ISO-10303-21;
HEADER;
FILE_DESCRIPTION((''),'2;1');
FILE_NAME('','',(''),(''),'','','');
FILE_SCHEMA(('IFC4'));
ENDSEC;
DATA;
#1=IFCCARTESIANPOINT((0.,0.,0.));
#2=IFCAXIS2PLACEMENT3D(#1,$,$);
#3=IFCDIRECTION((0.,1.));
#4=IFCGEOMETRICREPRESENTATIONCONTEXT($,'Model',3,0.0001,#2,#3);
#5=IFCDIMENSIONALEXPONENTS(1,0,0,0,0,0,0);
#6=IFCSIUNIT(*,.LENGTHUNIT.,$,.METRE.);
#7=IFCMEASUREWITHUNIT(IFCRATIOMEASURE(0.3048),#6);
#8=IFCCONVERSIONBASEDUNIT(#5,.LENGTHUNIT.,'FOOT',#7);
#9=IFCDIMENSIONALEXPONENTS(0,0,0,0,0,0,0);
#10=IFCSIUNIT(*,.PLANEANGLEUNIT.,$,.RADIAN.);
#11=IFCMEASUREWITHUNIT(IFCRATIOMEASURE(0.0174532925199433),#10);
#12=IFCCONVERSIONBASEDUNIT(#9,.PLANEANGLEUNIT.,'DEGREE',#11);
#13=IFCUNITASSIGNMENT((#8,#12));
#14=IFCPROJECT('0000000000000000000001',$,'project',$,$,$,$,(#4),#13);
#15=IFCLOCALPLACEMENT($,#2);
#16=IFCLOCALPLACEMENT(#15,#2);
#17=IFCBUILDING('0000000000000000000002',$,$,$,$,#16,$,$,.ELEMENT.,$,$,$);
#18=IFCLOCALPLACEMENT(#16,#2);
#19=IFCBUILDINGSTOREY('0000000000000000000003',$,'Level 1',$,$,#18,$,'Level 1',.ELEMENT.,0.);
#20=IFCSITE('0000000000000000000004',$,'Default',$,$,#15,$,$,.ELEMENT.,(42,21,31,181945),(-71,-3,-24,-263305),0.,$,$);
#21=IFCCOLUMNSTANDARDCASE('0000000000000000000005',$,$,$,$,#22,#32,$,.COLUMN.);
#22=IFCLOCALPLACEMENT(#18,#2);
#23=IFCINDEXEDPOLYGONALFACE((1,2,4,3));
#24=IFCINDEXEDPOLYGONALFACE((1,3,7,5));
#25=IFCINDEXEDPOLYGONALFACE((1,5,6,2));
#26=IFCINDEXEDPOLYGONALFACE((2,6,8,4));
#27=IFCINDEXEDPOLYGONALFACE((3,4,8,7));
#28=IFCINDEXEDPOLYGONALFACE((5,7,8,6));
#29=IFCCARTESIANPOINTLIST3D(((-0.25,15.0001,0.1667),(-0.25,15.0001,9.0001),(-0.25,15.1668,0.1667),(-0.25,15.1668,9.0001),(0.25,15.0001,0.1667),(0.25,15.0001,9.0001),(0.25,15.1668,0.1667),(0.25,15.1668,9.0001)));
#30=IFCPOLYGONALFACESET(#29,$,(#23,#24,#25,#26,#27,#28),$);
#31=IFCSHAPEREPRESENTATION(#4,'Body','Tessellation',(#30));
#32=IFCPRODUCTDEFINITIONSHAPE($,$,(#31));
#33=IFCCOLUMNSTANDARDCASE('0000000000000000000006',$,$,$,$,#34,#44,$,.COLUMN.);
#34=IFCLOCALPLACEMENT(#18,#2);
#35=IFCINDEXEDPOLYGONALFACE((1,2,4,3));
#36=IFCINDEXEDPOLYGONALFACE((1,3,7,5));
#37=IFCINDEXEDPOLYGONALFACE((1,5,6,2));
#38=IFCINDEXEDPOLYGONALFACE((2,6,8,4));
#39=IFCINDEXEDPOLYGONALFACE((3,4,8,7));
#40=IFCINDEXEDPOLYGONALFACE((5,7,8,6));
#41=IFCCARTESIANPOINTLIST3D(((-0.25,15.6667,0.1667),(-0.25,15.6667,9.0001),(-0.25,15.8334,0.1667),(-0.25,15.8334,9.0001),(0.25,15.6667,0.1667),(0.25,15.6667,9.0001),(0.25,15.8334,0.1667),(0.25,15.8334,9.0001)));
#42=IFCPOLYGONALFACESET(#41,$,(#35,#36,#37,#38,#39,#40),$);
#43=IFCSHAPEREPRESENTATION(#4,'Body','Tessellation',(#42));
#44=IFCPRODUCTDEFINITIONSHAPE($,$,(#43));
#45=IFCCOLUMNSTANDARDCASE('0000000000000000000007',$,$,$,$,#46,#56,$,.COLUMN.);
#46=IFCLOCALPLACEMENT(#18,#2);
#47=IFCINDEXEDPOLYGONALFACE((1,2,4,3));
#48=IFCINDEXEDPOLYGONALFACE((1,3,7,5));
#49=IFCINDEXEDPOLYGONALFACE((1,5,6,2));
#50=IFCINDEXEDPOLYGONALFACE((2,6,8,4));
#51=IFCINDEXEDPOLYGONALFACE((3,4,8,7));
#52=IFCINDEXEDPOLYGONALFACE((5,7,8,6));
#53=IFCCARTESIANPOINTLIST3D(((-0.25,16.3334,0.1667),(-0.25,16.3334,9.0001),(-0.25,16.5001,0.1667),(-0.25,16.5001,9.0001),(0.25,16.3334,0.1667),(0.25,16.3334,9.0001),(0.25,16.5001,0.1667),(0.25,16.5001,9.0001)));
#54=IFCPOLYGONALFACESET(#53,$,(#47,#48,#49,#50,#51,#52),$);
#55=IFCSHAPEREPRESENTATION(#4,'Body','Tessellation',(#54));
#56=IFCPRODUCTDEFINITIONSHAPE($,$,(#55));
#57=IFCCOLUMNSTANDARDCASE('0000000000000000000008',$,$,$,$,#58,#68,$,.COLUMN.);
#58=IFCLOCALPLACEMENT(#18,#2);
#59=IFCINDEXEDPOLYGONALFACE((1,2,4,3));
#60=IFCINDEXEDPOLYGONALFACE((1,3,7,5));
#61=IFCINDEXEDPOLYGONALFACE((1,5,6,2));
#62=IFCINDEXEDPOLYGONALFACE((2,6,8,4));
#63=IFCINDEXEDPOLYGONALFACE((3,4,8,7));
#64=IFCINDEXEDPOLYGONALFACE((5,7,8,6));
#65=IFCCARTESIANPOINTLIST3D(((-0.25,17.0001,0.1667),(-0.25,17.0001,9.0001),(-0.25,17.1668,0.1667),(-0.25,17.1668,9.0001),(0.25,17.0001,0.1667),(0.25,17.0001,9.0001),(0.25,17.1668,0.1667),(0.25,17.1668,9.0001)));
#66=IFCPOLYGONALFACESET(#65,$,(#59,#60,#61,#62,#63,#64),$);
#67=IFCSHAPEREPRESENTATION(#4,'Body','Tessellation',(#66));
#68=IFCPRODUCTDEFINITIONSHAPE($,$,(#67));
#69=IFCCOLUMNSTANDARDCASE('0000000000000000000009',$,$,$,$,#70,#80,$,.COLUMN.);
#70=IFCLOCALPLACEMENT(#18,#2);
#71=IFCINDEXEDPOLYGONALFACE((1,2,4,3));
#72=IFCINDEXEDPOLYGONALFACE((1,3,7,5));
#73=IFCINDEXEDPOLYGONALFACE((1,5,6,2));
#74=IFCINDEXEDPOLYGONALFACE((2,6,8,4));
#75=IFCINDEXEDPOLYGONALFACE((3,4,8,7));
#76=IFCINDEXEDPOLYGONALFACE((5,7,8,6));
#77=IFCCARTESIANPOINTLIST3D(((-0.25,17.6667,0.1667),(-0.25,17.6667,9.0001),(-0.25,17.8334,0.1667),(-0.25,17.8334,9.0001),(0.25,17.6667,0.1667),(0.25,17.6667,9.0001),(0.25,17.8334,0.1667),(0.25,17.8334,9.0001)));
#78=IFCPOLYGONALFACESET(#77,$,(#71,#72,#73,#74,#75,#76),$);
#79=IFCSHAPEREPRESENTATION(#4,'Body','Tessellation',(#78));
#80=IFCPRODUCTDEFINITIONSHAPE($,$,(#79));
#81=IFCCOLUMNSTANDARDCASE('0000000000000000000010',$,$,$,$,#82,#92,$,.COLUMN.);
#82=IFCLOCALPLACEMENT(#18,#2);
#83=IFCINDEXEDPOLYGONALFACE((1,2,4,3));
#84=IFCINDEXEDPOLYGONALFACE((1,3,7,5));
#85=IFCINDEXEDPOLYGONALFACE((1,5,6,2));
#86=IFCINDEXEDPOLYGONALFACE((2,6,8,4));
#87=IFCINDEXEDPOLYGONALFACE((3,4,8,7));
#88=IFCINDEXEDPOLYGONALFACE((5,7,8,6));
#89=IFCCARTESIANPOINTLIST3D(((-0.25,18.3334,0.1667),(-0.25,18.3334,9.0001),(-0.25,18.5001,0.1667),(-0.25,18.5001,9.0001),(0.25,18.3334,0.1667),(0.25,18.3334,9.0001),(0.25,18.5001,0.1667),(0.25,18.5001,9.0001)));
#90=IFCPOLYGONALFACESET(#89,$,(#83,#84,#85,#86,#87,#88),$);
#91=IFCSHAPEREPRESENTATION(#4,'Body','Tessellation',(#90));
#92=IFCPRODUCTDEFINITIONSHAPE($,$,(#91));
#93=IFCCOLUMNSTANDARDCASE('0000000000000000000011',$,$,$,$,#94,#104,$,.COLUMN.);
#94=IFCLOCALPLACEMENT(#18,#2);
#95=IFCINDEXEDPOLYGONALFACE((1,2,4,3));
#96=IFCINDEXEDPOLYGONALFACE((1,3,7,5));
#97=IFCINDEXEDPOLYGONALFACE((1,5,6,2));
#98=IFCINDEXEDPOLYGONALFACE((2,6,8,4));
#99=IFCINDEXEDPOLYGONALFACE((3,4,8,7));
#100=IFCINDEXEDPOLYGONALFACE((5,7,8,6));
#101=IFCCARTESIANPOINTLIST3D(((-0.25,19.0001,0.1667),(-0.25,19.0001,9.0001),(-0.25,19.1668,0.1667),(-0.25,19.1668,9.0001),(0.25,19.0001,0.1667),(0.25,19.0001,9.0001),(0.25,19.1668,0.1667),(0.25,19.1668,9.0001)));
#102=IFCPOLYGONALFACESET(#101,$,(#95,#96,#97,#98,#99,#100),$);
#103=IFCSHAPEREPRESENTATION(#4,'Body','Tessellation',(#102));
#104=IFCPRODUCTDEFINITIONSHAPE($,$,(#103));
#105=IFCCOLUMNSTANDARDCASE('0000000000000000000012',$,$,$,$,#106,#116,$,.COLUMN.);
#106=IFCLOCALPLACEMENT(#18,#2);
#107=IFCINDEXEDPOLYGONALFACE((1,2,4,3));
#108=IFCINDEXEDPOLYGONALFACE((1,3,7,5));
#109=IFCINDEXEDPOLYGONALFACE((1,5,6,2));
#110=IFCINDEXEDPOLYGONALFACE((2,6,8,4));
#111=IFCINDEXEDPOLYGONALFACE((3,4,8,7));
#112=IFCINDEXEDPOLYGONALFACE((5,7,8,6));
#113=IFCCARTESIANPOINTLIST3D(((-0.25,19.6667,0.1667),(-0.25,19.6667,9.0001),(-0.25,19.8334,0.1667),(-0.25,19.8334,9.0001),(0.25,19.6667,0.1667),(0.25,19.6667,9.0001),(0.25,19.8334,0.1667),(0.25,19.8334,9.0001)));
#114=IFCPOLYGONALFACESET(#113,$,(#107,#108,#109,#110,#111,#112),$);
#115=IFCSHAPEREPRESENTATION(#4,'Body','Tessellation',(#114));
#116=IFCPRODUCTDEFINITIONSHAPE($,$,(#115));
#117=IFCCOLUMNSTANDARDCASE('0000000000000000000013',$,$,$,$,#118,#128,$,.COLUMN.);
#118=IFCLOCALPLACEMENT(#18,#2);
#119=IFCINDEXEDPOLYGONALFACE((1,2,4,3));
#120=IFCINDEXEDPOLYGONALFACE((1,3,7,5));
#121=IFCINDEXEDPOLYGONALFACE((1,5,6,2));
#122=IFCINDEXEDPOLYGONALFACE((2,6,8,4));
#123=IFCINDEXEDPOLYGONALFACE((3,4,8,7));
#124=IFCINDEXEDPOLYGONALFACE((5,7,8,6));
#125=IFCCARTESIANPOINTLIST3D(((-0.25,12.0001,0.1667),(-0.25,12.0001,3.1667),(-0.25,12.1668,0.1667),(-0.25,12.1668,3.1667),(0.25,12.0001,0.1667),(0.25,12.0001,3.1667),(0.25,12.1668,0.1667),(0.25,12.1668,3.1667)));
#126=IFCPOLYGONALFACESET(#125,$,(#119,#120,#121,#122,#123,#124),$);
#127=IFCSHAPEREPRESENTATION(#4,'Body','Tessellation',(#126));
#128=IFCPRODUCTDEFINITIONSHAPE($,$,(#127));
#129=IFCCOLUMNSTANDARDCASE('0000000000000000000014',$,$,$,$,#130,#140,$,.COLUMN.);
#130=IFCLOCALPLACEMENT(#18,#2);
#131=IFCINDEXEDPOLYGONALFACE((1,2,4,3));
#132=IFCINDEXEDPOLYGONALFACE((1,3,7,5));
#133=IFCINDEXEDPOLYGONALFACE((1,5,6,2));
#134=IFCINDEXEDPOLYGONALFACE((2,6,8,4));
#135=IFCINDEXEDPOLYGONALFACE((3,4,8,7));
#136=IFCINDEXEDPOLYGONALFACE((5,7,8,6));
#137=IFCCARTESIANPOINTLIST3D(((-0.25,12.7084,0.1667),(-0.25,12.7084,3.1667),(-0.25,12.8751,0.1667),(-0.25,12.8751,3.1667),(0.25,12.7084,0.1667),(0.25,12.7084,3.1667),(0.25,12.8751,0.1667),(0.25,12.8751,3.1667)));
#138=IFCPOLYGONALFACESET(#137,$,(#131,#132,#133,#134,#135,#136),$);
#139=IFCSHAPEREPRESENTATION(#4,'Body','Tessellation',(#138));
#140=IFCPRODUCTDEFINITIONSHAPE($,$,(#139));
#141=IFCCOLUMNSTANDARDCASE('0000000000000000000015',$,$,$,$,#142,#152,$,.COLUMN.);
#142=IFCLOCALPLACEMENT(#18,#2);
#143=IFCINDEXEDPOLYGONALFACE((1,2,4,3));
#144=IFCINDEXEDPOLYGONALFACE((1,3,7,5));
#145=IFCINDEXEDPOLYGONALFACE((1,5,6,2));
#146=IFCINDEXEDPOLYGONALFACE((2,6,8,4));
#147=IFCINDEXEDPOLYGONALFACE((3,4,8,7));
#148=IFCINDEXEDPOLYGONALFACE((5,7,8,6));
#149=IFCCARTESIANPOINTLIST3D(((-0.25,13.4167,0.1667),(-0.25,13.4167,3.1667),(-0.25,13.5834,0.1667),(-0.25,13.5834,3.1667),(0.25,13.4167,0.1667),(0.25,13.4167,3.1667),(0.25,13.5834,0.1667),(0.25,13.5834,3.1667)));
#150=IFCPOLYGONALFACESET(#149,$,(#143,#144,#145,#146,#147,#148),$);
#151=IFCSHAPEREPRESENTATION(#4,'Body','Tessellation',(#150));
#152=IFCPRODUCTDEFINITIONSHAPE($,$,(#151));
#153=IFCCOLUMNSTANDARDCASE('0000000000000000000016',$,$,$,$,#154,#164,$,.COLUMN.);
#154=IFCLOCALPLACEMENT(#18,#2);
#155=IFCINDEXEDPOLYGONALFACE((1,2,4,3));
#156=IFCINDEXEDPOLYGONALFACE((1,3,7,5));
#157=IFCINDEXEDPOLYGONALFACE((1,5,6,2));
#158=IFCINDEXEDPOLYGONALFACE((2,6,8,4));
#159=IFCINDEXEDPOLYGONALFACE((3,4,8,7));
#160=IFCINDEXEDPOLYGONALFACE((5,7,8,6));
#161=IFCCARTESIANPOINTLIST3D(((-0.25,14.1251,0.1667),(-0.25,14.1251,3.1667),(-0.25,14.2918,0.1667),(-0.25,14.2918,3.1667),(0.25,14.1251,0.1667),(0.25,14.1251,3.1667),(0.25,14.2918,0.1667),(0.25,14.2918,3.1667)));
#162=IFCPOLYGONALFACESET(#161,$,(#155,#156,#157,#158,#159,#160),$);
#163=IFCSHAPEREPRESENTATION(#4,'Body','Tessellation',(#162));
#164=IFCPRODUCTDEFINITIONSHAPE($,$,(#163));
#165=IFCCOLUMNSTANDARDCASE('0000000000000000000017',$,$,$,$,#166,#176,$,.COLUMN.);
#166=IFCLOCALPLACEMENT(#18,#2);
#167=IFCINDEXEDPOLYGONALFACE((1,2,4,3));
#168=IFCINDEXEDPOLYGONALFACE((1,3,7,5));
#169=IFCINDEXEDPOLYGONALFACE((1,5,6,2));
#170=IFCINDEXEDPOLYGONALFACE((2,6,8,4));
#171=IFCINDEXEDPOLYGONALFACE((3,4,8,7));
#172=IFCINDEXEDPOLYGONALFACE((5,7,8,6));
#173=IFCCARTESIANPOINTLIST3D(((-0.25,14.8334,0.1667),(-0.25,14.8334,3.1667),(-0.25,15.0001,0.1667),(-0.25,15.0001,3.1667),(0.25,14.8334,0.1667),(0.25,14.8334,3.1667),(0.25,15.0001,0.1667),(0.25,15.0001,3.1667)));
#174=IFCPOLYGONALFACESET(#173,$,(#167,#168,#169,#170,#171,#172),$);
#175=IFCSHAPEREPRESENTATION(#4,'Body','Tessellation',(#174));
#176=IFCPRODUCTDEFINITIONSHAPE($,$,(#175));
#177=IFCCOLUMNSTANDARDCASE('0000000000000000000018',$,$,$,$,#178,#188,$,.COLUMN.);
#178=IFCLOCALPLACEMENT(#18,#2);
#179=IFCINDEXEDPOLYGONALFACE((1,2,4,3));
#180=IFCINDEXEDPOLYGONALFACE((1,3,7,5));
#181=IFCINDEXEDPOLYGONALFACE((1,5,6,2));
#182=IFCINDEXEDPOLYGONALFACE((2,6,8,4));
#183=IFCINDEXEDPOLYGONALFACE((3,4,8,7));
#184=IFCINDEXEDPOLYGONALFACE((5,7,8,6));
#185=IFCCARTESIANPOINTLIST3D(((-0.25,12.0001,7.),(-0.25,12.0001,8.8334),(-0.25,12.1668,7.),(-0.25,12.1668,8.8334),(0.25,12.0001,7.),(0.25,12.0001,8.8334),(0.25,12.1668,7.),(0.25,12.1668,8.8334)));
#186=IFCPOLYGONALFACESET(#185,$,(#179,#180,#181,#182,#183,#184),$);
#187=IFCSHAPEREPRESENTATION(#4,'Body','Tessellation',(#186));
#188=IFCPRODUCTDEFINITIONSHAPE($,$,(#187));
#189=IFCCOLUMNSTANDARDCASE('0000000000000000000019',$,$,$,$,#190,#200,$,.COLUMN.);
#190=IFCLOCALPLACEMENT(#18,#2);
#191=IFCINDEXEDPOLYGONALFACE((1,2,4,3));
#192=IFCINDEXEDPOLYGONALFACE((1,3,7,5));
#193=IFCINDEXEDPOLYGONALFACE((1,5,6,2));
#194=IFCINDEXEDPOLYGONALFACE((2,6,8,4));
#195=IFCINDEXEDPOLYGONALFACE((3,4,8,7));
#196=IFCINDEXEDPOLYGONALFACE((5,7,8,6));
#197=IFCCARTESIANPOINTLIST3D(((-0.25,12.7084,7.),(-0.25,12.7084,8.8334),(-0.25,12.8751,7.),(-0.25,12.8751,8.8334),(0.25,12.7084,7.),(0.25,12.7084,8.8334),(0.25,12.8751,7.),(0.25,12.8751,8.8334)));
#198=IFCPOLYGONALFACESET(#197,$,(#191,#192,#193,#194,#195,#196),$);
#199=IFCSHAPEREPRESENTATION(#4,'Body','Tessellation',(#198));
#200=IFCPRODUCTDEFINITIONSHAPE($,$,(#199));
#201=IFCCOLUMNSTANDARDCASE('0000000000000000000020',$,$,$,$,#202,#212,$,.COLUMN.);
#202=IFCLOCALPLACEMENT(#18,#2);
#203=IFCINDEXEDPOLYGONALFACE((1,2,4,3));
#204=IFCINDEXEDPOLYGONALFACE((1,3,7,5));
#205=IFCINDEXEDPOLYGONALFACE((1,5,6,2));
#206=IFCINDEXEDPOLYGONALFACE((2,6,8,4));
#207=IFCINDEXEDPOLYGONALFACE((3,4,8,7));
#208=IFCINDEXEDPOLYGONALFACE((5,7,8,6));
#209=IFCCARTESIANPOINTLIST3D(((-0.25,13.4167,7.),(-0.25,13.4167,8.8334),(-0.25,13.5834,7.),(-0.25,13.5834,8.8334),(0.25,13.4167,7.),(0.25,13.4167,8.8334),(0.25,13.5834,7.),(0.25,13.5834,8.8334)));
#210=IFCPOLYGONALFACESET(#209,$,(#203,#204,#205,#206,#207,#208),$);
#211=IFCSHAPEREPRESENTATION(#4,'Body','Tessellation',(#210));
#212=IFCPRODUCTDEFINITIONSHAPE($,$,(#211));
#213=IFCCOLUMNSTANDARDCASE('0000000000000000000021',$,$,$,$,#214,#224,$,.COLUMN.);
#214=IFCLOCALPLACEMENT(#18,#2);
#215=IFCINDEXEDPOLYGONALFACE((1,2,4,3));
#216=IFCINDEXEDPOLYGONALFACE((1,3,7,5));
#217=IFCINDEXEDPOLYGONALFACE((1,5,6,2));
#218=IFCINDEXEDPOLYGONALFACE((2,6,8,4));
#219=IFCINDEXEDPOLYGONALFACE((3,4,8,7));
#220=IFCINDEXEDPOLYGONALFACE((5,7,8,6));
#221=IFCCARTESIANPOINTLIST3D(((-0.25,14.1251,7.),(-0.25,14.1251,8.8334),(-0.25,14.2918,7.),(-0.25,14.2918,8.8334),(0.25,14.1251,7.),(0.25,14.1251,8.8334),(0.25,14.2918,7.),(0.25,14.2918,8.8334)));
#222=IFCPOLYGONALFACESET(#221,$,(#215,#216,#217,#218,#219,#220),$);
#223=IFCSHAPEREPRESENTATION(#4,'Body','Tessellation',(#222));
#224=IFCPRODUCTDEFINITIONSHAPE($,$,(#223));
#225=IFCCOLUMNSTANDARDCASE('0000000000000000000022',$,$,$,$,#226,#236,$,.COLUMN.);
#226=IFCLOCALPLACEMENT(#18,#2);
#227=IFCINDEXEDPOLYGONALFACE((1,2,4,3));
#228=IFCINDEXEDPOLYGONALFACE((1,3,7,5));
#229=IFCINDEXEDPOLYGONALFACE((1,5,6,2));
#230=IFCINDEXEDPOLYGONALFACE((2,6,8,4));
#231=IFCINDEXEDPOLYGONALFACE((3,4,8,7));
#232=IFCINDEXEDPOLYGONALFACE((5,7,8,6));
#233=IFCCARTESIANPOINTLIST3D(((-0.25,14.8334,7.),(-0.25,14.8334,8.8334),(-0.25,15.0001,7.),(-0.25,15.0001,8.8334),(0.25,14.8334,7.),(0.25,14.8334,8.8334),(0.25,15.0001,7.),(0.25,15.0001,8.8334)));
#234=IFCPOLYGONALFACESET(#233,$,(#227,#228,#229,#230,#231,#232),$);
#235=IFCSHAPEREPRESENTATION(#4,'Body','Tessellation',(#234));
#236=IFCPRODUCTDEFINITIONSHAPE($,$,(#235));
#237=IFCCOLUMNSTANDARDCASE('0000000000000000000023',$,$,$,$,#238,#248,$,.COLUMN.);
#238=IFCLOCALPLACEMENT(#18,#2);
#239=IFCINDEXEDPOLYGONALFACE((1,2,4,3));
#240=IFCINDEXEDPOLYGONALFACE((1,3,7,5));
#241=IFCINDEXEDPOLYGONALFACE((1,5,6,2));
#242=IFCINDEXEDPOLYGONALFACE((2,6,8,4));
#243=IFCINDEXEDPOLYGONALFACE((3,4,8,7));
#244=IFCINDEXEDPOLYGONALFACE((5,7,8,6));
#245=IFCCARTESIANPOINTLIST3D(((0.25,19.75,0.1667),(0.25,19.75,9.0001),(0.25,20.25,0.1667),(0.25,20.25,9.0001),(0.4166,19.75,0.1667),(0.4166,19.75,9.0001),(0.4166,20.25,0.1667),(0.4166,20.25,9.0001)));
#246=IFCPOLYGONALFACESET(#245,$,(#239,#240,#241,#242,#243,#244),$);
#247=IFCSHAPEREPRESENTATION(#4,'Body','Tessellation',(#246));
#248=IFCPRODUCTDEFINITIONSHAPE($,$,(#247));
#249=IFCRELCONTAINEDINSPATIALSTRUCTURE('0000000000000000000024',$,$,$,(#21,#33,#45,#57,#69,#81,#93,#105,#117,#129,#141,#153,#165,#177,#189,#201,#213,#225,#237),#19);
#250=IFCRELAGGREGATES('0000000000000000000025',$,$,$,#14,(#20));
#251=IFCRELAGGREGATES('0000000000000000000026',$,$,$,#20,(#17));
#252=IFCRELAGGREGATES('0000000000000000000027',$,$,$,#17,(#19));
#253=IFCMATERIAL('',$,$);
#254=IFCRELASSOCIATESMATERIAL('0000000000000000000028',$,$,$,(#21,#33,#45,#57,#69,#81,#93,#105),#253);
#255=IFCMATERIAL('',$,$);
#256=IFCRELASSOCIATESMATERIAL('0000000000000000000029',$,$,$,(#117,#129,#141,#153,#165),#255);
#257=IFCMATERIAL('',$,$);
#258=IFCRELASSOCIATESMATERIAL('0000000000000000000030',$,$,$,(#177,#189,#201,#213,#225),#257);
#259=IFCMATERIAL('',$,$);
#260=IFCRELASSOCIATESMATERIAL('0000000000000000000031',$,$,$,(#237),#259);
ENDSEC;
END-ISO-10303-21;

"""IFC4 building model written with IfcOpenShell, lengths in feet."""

from ifc_helpers import new_model, entity, si_unit, converted_unit, direction, frame, origin, place, context, project, spatial, rectangle, extrude, material, element, save


model = new_model("IFC4")

# Units and contexts
model_context = context("Model", 3, precision=0.0001, world=origin(), true_north=direction((0.0, 1.0)))
ifc_project = project(units=[converted_unit("LENGTHUNIT", "FOOT", entity("IfcRatioMeasure", 0.3048), si_unit("LENGTHUNIT", "METRE"), dimensions=[1, 0, 0, 0, 0, 0, 0]), converted_unit("PLANEANGLEUNIT", "DEGREE", entity("IfcRatioMeasure", 0.0174532925199433), si_unit("PLANEANGLEUNIT", "RADIAN"), dimensions=[0, 0, 0, 0, 0, 0, 0])], contexts=[model_context])

# Site, building, storey
site_placement = place(None, origin())
site = spatial("IfcSite", under=ifc_project, at=site_placement, Name="Default", CompositionType="ELEMENT", RefLatitude=(42, 21, 31, 181945), RefLongitude=(-71, -3, -24, -263305), RefElevation=0.0)
building_placement = place(site_placement, origin())
building = spatial("IfcBuilding", under=site, at=building_placement, CompositionType="ELEMENT")
storey_placement = place(building_placement, origin())
storey = spatial("IfcBuildingStorey", under=building, at=storey_placement, Name="Level 1", LongName="Level 1", CompositionType="ELEMENT", Elevation=0.0)

# Columns
ifc_material_1 = material(Name="")
placement_1 = place(storey_placement, frame((0.0, -0.25, 0.0), z_axis=(0.0, 0.0, 1.0), x_axis=(0.0, 1.0, 0.0)))
for number, where, z_axis, x_axis in (
    (1, (15.3334, 0.0, 0.1667), (0.0, 0.0, 1.0), (1.0, 0.0, 0.0)),
    (2, (16.0, 0.0, 0.1667), (0.0, 0.0, 1.0), (1.0, 0.0, 0.0)),
    (3, (16.6667, 0.0, 0.1667), (0.0, 0.0, 1.0), (1.0, 0.0, 0.0)),
    (4, (17.3334, 0.0, 0.1667), (0.0, 0.0, 1.0), (1.0, 0.0, 0.0)),
    (5, (18.0, 0.0, 0.1667), (0.0, 0.0, 1.0), (1.0, 0.0, 0.0)),
    (6, (18.6667, 0.0, 0.1667), (0.0, 0.0, 1.0), (1.0, 0.0, 0.0)),
    (7, (19.3334, 0.0, 0.1667), (0.0, 0.0, 1.0), (1.0, 0.0, 0.0)),
    (8, (20.0, 0.0, 0.1667), (0.0, 0.0, 1.0), (1.0, 0.0, 0.0)),
):
    element("IfcColumnStandardCase", number, at=place(placement_1, frame(where, z_axis=z_axis, x_axis=x_axis)), inside=storey, material=ifc_material_1, PredefinedType="COLUMN", context=model_context, shape_type="SweptSolid", body=[
        extrude(rectangle(XDim=0.1667, YDim=0.5), origin(), (0.0, 0.0, 1.0), 8.8334),
    ])
ifc_material_2 = material(Name="")
for number, where, z_axis, x_axis in (
    (9, (12.3334, 0.0, 0.1667), (0.0, 0.0, 1.0), (1.0, 0.0, 0.0)),
    (10, (13.0417, 0.0, 0.1667), (0.0, 0.0, 1.0), (1.0, 0.0, 0.0)),
    (11, (13.75, 0.0, 0.1667), (0.0, 0.0, 1.0), (1.0, 0.0, 0.0)),
    (12, (14.4584, 0.0, 0.1667), (0.0, 0.0, 1.0), (1.0, 0.0, 0.0)),
    (13, (15.1667, 0.0, 0.1667), (0.0, 0.0, 1.0), (1.0, 0.0, 0.0)),
):
    element("IfcColumnStandardCase", number, at=place(placement_1, frame(where, z_axis=z_axis, x_axis=x_axis)), inside=storey, material=ifc_material_2, PredefinedType="COLUMN", context=model_context, shape_type="SweptSolid", body=[
        extrude(rectangle(XDim=0.1667, YDim=0.5), origin(), (0.0, 0.0, 1.0), 3.0),
    ])
ifc_material_3 = material(Name="")
for number, where, z_axis, x_axis in (
    (14, (12.3334, 0.0, 7.0), (0.0, 0.0, 1.0), (1.0, 0.0, 0.0)),
    (15, (13.0417, 0.0, 7.0), (0.0, 0.0, 1.0), (1.0, 0.0, 0.0)),
    (16, (13.75, 0.0, 7.0), (0.0, 0.0, 1.0), (1.0, 0.0, 0.0)),
    (17, (14.4584, 0.0, 7.0), (0.0, 0.0, 1.0), (1.0, 0.0, 0.0)),
    (18, (15.1667, 0.0, 7.0), (0.0, 0.0, 1.0), (1.0, 0.0, 0.0)),
):
    element("IfcColumnStandardCase", number, at=place(placement_1, frame(where, z_axis=z_axis, x_axis=x_axis)), inside=storey, material=ifc_material_3, PredefinedType="COLUMN", context=model_context, shape_type="SweptSolid", body=[
        extrude(rectangle(XDim=0.1667, YDim=0.5), origin(), (0.0, 0.0, 1.0), 1.8334),
    ])
ifc_material_4 = material(Name="")
placement_2 = place(storey_placement, frame((0.25, 20.0, 0.0)))
for number, where, z_axis, x_axis in (
    (19, (0.0833, 0.0, 0.1667), (0.0, 0.0, 1.0), (1.0, 0.0, 0.0)),
):
    element("IfcColumnStandardCase", number, at=place(placement_2, frame(where, z_axis=z_axis, x_axis=x_axis)), inside=storey, material=ifc_material_4, PredefinedType="COLUMN", context=model_context, shape_type="SweptSolid", body=[
        extrude(rectangle(XDim=0.1667, YDim=0.5), origin(), (0.0, 0.0, 1.0), 8.8334),
    ])

save(model, "model.ifc")
